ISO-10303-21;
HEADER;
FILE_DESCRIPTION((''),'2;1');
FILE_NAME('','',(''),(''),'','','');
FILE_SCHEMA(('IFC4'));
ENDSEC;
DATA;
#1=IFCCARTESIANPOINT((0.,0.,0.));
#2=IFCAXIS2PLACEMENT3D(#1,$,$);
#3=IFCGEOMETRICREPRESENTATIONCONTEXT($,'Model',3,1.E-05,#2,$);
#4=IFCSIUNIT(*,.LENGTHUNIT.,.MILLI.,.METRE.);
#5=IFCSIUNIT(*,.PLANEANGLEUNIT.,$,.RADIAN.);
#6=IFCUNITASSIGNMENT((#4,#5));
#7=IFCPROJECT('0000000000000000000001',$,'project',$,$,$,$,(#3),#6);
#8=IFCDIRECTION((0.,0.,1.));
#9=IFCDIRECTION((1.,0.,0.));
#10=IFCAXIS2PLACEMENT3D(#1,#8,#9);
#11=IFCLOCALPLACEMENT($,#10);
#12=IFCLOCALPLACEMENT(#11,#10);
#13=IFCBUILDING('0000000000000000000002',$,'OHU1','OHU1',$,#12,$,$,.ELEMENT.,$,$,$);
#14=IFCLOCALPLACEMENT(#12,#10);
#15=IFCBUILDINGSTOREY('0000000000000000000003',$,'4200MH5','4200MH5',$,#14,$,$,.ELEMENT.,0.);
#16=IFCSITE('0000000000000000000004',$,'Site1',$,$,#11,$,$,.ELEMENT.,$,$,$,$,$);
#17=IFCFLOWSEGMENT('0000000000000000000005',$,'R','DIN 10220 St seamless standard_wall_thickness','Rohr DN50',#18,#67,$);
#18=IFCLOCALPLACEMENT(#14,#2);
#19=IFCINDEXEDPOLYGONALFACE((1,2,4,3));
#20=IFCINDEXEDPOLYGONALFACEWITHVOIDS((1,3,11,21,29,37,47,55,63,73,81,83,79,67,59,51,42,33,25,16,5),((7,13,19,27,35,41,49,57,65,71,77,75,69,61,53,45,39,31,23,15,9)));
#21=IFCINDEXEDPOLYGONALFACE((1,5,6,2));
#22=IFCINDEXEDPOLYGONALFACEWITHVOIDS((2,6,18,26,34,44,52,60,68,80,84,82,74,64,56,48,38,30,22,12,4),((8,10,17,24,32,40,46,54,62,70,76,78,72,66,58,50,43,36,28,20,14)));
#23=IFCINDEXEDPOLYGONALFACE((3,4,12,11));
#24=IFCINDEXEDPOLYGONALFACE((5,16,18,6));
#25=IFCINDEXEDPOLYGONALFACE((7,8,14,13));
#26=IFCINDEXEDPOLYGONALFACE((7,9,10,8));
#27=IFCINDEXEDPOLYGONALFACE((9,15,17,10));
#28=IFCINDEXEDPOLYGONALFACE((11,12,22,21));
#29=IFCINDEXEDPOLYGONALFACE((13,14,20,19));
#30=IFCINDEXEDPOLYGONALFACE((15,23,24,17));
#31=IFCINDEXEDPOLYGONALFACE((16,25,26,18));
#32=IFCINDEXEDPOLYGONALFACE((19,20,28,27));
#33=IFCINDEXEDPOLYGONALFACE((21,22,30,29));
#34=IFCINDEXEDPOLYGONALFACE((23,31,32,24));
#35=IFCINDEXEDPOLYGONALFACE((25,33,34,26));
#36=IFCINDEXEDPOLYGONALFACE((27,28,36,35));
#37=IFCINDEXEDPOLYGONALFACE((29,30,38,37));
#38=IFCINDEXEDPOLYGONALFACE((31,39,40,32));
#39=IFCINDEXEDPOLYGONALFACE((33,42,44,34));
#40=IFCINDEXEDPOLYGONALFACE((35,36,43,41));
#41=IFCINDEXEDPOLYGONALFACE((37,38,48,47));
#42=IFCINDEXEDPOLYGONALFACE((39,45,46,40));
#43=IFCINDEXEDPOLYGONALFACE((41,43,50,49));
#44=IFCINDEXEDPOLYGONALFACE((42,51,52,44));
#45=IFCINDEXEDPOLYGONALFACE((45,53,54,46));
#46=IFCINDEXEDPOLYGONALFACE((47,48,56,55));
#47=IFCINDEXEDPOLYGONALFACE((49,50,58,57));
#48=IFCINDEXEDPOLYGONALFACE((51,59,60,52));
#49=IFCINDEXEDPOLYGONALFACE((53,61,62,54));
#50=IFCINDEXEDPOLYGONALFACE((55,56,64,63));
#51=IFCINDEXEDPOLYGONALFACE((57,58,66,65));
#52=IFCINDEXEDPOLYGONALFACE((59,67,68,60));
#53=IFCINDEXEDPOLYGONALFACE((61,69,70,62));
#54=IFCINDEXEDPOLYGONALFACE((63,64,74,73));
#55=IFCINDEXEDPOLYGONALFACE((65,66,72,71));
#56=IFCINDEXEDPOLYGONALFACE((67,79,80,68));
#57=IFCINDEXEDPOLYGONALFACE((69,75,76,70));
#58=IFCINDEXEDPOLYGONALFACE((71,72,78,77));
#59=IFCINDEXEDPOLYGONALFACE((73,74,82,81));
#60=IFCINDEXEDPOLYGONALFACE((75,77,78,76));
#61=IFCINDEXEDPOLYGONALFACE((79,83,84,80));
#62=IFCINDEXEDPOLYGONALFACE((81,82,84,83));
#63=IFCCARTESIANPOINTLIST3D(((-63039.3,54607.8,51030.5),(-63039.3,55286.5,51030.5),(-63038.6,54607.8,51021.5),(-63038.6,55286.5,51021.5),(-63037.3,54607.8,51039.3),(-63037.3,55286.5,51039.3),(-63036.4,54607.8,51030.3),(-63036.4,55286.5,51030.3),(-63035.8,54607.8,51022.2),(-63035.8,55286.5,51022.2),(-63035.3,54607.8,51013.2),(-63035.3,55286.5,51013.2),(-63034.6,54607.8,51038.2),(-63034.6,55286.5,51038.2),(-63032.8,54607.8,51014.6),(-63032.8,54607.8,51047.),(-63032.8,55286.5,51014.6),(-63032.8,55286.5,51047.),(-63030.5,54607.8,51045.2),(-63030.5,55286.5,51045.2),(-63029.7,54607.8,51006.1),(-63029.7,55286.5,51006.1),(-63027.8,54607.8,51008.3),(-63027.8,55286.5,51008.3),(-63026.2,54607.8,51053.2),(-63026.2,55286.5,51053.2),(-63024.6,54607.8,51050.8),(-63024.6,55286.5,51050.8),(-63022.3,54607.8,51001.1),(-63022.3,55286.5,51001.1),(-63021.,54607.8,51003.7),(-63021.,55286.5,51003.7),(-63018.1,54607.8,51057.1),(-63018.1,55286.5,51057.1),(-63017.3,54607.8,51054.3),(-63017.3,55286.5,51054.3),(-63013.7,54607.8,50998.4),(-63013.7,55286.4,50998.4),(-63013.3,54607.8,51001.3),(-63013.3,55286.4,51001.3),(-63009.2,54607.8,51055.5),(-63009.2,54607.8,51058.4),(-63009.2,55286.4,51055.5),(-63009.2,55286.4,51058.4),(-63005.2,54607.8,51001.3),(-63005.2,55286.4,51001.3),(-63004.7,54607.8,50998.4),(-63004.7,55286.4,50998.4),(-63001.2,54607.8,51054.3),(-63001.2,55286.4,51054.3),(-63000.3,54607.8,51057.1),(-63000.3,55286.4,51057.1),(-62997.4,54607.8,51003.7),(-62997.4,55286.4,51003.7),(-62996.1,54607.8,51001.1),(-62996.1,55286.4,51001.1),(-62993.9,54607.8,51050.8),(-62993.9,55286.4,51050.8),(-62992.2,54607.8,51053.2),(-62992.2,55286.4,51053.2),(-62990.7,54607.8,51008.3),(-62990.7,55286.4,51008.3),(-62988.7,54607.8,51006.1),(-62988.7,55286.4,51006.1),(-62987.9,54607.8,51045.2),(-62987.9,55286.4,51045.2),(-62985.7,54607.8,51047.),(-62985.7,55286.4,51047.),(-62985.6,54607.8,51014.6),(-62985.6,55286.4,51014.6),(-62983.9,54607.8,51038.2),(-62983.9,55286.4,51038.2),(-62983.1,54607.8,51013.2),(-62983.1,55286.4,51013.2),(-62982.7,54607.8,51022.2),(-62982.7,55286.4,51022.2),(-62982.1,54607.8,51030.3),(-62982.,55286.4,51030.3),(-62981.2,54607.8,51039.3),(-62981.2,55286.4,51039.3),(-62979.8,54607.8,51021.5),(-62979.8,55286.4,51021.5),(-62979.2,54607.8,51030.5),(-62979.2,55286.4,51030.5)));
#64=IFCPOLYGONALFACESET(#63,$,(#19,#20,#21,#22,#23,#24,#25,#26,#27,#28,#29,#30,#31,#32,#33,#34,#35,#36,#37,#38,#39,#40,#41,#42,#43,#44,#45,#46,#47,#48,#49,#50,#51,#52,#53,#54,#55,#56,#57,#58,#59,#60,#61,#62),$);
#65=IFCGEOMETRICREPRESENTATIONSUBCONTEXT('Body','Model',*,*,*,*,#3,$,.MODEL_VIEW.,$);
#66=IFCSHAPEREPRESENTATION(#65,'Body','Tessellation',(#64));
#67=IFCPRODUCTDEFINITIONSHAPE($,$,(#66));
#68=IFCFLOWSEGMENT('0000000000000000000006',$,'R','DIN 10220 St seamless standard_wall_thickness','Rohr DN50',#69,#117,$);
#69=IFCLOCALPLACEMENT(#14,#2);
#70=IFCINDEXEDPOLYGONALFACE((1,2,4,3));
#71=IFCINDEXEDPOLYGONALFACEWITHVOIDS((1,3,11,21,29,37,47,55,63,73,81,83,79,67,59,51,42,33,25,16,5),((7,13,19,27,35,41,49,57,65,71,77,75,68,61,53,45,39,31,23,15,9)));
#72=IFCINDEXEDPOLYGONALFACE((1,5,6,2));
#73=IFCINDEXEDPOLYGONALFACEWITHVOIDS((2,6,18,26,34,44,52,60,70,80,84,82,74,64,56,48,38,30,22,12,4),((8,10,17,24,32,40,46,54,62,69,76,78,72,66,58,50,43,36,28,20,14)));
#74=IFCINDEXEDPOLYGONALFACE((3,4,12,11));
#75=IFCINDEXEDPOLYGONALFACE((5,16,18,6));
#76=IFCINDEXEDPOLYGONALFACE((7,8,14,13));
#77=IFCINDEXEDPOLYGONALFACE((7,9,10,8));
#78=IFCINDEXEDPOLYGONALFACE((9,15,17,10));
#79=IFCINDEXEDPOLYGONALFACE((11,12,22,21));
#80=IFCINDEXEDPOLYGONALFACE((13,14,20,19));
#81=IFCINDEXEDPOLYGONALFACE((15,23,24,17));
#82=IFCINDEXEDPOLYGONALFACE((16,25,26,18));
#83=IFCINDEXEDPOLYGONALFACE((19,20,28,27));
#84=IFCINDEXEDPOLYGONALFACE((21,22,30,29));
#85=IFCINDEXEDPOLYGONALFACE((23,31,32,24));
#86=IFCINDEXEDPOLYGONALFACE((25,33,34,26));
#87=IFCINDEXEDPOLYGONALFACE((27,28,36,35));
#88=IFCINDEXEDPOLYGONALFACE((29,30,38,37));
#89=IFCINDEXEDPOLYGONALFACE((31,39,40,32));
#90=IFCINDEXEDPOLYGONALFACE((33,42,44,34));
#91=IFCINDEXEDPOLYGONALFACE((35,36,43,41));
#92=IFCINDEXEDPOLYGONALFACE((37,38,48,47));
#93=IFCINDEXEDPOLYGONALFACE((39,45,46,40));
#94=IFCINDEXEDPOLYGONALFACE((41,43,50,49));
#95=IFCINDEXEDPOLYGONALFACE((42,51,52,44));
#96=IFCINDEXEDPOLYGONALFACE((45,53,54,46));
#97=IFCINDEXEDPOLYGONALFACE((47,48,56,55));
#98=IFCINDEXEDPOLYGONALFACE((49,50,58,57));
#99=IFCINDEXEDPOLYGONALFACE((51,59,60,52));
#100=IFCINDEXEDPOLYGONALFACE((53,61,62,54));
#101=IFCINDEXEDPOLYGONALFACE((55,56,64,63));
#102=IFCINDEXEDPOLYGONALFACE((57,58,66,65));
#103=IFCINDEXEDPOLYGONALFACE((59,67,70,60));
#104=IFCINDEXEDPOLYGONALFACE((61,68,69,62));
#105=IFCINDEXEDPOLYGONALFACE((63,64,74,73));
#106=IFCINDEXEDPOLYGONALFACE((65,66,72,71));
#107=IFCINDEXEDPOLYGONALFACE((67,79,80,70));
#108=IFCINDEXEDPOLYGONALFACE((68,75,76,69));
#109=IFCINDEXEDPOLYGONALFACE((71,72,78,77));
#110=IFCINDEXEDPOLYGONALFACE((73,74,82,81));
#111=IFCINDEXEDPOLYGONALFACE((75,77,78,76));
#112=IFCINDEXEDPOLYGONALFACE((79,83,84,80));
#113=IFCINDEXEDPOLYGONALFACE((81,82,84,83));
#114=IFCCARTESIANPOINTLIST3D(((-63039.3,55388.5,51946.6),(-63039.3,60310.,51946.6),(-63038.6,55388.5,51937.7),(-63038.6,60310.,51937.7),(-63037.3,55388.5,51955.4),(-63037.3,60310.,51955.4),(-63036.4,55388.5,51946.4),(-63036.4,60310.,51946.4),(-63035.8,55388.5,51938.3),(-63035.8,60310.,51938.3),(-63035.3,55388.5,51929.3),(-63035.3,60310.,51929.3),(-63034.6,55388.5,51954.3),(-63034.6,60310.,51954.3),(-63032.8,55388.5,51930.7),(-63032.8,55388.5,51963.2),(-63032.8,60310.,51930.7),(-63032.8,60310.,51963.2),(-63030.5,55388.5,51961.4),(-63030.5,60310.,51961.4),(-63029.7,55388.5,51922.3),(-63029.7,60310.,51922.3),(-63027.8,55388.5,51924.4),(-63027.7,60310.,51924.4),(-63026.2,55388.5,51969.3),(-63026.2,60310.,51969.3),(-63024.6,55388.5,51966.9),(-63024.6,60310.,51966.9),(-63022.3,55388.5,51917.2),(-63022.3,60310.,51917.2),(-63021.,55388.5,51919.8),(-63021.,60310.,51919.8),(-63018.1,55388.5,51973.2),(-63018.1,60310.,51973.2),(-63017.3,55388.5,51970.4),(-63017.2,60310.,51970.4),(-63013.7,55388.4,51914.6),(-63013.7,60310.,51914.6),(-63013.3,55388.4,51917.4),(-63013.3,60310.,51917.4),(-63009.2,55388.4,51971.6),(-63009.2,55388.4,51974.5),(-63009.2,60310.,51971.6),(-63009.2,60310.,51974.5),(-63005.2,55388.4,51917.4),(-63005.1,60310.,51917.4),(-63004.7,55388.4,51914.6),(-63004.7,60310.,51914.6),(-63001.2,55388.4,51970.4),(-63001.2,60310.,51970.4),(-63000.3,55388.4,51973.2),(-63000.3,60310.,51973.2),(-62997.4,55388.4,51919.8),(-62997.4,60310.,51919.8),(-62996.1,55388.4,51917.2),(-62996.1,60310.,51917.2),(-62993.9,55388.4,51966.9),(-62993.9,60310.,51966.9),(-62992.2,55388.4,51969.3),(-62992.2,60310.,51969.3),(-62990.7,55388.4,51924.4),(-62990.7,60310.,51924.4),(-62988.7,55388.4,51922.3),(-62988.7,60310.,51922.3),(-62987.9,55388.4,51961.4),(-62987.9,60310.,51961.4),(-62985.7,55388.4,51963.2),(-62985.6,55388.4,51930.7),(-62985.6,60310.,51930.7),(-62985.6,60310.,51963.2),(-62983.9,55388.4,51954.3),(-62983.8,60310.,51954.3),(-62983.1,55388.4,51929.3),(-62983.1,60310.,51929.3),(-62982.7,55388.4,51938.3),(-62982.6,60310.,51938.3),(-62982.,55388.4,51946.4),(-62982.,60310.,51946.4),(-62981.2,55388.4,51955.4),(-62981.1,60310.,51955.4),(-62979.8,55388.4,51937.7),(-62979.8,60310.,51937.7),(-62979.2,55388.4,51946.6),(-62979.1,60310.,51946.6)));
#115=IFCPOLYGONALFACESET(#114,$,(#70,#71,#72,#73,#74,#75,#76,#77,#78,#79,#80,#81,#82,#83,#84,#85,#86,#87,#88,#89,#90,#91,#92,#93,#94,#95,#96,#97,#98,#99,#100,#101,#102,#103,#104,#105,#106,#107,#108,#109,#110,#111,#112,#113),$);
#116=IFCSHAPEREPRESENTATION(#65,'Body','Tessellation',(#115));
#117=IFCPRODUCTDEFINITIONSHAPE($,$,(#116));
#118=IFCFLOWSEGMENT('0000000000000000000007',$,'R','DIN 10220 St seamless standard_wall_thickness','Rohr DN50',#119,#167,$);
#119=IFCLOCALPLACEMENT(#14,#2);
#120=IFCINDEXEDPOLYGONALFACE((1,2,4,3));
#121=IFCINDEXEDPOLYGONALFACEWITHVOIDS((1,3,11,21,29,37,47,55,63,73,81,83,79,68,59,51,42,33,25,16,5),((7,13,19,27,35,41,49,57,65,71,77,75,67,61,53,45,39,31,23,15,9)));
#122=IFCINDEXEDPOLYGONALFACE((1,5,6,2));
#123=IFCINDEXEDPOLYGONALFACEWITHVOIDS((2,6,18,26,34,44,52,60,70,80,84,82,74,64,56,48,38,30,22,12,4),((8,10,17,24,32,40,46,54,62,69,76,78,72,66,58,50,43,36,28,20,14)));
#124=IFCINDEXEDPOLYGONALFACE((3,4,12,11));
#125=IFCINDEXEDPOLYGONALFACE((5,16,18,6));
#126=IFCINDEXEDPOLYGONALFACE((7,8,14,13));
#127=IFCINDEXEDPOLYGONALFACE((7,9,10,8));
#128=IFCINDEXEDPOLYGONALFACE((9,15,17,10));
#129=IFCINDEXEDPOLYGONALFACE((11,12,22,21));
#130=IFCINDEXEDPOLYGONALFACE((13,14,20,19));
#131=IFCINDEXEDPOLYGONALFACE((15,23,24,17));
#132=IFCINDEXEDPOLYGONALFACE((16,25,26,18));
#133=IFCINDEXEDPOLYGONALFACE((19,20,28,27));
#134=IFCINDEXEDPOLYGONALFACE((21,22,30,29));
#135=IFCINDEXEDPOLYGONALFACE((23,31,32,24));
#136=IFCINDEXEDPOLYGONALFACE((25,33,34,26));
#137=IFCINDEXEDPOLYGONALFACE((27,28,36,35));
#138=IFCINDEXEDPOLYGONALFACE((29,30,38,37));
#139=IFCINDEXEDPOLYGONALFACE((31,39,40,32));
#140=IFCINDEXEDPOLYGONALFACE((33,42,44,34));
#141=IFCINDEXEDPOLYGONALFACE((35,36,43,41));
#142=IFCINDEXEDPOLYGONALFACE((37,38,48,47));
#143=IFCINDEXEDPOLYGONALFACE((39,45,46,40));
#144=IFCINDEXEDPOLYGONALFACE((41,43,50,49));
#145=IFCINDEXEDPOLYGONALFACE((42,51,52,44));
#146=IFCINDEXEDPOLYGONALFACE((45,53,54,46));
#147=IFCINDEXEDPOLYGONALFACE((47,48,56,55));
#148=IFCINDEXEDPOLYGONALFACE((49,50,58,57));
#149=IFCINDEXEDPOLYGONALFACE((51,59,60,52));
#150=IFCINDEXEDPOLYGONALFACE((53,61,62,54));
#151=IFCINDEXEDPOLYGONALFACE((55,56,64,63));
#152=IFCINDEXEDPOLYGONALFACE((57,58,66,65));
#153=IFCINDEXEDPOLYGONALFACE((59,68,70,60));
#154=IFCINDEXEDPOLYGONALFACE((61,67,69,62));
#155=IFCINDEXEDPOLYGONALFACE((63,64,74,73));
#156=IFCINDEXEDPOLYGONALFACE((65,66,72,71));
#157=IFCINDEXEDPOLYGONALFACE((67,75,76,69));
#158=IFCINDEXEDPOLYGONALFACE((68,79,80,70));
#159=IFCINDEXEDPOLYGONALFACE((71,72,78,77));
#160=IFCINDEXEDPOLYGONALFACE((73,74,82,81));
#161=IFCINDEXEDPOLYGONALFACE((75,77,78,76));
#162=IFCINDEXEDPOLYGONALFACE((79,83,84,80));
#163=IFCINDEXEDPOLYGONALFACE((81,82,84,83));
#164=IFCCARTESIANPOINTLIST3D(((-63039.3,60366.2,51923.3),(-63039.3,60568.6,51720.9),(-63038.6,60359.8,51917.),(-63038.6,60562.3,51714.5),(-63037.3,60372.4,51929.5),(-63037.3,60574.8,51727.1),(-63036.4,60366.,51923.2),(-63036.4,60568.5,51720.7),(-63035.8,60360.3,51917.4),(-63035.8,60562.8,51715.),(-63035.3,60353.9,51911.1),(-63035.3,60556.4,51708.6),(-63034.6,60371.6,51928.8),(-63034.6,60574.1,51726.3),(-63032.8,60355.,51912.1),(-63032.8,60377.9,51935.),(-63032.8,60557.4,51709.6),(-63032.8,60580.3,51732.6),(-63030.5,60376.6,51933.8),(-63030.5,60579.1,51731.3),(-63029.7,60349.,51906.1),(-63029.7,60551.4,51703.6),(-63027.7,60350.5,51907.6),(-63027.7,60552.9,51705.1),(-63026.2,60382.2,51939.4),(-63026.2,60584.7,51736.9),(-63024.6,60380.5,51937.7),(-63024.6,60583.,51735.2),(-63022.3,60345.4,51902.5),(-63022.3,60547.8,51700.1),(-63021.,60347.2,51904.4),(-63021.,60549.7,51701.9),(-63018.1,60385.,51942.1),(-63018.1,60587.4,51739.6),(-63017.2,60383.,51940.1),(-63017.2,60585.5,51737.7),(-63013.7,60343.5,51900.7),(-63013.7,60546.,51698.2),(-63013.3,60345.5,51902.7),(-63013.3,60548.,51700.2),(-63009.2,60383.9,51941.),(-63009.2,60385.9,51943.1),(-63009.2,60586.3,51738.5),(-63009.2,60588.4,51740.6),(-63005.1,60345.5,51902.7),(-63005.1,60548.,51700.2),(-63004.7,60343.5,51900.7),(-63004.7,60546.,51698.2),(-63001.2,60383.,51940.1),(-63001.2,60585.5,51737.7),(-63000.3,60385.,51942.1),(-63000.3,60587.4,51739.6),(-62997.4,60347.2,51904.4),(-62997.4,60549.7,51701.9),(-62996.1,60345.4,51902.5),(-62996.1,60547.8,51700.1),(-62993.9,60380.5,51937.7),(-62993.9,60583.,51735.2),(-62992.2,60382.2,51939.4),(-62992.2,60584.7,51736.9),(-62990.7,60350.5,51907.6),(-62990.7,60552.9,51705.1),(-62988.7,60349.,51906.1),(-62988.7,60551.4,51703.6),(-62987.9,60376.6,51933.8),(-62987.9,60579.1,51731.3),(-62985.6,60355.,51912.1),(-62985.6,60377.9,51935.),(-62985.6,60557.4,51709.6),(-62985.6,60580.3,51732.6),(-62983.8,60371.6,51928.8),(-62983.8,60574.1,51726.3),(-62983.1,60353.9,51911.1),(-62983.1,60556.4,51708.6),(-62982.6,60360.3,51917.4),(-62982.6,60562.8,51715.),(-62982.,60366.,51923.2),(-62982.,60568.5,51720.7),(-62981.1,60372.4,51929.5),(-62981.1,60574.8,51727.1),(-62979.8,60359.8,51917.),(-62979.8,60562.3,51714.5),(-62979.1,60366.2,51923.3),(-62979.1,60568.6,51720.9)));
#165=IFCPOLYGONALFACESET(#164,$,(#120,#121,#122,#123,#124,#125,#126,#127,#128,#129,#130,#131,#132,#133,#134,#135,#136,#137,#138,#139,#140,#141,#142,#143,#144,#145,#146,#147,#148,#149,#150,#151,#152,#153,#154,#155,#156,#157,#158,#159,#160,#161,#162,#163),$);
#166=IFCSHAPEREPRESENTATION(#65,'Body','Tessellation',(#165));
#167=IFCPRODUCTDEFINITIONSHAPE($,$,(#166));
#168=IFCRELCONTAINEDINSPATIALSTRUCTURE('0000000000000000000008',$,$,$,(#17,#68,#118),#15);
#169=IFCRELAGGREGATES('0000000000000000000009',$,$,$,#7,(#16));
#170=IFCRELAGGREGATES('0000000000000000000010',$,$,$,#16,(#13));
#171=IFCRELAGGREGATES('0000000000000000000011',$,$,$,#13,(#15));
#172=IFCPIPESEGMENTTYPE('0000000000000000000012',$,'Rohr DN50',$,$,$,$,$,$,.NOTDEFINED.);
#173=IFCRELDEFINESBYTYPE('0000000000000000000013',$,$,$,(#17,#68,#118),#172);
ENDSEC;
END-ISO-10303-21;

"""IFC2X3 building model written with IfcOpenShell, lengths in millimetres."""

from ifc_helpers import new_model, si_unit, frame, origin, origin_with_axes, origin_2d_with_axis, place, context, subcontext, project, spatial, hollow_circle, extrude, type_object, element, save


model = new_model("IFC2X3")

# Units and contexts
model_context = context("Model", 3, precision=1e-05, world=origin())
body_context = subcontext(model_context, "Body", "Model", "MODEL_VIEW")
ifc_project = project(units=[si_unit("LENGTHUNIT", "METRE", prefix="MILLI"), si_unit("PLANEANGLEUNIT", "RADIAN")], contexts=[model_context])

# Site, building, storey
site_placement = place(None, origin_with_axes())
site = spatial("IfcSite", under=ifc_project, at=site_placement, Name="Site1", CompositionType="ELEMENT")
building_placement = place(site_placement, origin_with_axes())
building = spatial("IfcBuilding", under=site, at=building_placement, Name="OHU1", Description="OHU1", CompositionType="ELEMENT")
storey_placement = place(building_placement, origin_with_axes())
storey = spatial("IfcBuildingStorey", under=building, at=storey_placement, Name="4200MH5", Description="4200MH5", CompositionType="ELEMENT", Elevation=0.0)

# Flow segments
pipe_segment_type_1 = type_object("IfcPipeSegmentType", Name="Rohr DN50", PredefinedType="NOTDEFINED")
flow_segment_1_placement = place(storey_placement, frame((-63009.2, 54947.1, 51028.3), z_axis=(0.0, 0.0, 1.0), x_axis=(1.0, 0.0, 0.0)))
element("IfcFlowSegment", 1, at=flow_segment_1_placement, inside=storey, type_object=pipe_segment_type_1, Name="R", Description="DIN 10220 St seamless standard_wall_thickness", ObjectType="Rohr DN50", context=body_context, shape_type="SweptSolid", body=[
    extrude(hollow_circle(Radius=30.1, WallThickness=2.9, at=origin_2d_with_axis()), frame((0.0, -339.3, 0.0), z_axis=(0.000003, 1.0, 0.0), x_axis=(0.0, 0.0, 1.0)), (0.0, 0.0, 1.0), 678.7),
])
flow_segment_2_placement = place(storey_placement, frame((-63009.2, 57849.2, 51944.4), z_axis=(0.0, 0.0, 1.0), x_axis=(1.0, 0.0, 0.0)))
element("IfcFlowSegment", 2, at=flow_segment_2_placement, inside=storey, type_object=pipe_segment_type_1, Name="R", Description="DIN 10220 St seamless standard_wall_thickness", ObjectType="Rohr DN50", context=body_context, shape_type="SweptSolid", body=[
    extrude(hollow_circle(Radius=30.1, WallThickness=2.9, at=origin_2d_with_axis()), frame((0.0, -2460.8, 0.0), z_axis=(0.000003, 1.0, 0.0), x_axis=(0.0, 0.0, 1.0)), (0.0, 0.0, 1.0), 4921.5),
])
flow_segment_3_placement = place(storey_placement, frame((-63009.2, 60465.8, 51820.5), z_axis=(0.0, 0.0, 1.0), x_axis=(1.0, 0.0, 0.0)))
element("IfcFlowSegment", 3, at=flow_segment_3_placement, inside=storey, type_object=pipe_segment_type_1, Name="R", Description="DIN 10220 St seamless standard_wall_thickness", ObjectType="Rohr DN50", context=body_context, shape_type="SweptSolid", body=[
    extrude(hollow_circle(Radius=30.1, WallThickness=2.9, at=origin_2d_with_axis()), frame((0.0, -101.2, 101.2), z_axis=(0.000002, 0.707107, -0.707107), x_axis=(0.0, 0.0, 1.0)), (0.0, 0.0, 1.0), 286.3),
])

save(model, "model.ifc")
